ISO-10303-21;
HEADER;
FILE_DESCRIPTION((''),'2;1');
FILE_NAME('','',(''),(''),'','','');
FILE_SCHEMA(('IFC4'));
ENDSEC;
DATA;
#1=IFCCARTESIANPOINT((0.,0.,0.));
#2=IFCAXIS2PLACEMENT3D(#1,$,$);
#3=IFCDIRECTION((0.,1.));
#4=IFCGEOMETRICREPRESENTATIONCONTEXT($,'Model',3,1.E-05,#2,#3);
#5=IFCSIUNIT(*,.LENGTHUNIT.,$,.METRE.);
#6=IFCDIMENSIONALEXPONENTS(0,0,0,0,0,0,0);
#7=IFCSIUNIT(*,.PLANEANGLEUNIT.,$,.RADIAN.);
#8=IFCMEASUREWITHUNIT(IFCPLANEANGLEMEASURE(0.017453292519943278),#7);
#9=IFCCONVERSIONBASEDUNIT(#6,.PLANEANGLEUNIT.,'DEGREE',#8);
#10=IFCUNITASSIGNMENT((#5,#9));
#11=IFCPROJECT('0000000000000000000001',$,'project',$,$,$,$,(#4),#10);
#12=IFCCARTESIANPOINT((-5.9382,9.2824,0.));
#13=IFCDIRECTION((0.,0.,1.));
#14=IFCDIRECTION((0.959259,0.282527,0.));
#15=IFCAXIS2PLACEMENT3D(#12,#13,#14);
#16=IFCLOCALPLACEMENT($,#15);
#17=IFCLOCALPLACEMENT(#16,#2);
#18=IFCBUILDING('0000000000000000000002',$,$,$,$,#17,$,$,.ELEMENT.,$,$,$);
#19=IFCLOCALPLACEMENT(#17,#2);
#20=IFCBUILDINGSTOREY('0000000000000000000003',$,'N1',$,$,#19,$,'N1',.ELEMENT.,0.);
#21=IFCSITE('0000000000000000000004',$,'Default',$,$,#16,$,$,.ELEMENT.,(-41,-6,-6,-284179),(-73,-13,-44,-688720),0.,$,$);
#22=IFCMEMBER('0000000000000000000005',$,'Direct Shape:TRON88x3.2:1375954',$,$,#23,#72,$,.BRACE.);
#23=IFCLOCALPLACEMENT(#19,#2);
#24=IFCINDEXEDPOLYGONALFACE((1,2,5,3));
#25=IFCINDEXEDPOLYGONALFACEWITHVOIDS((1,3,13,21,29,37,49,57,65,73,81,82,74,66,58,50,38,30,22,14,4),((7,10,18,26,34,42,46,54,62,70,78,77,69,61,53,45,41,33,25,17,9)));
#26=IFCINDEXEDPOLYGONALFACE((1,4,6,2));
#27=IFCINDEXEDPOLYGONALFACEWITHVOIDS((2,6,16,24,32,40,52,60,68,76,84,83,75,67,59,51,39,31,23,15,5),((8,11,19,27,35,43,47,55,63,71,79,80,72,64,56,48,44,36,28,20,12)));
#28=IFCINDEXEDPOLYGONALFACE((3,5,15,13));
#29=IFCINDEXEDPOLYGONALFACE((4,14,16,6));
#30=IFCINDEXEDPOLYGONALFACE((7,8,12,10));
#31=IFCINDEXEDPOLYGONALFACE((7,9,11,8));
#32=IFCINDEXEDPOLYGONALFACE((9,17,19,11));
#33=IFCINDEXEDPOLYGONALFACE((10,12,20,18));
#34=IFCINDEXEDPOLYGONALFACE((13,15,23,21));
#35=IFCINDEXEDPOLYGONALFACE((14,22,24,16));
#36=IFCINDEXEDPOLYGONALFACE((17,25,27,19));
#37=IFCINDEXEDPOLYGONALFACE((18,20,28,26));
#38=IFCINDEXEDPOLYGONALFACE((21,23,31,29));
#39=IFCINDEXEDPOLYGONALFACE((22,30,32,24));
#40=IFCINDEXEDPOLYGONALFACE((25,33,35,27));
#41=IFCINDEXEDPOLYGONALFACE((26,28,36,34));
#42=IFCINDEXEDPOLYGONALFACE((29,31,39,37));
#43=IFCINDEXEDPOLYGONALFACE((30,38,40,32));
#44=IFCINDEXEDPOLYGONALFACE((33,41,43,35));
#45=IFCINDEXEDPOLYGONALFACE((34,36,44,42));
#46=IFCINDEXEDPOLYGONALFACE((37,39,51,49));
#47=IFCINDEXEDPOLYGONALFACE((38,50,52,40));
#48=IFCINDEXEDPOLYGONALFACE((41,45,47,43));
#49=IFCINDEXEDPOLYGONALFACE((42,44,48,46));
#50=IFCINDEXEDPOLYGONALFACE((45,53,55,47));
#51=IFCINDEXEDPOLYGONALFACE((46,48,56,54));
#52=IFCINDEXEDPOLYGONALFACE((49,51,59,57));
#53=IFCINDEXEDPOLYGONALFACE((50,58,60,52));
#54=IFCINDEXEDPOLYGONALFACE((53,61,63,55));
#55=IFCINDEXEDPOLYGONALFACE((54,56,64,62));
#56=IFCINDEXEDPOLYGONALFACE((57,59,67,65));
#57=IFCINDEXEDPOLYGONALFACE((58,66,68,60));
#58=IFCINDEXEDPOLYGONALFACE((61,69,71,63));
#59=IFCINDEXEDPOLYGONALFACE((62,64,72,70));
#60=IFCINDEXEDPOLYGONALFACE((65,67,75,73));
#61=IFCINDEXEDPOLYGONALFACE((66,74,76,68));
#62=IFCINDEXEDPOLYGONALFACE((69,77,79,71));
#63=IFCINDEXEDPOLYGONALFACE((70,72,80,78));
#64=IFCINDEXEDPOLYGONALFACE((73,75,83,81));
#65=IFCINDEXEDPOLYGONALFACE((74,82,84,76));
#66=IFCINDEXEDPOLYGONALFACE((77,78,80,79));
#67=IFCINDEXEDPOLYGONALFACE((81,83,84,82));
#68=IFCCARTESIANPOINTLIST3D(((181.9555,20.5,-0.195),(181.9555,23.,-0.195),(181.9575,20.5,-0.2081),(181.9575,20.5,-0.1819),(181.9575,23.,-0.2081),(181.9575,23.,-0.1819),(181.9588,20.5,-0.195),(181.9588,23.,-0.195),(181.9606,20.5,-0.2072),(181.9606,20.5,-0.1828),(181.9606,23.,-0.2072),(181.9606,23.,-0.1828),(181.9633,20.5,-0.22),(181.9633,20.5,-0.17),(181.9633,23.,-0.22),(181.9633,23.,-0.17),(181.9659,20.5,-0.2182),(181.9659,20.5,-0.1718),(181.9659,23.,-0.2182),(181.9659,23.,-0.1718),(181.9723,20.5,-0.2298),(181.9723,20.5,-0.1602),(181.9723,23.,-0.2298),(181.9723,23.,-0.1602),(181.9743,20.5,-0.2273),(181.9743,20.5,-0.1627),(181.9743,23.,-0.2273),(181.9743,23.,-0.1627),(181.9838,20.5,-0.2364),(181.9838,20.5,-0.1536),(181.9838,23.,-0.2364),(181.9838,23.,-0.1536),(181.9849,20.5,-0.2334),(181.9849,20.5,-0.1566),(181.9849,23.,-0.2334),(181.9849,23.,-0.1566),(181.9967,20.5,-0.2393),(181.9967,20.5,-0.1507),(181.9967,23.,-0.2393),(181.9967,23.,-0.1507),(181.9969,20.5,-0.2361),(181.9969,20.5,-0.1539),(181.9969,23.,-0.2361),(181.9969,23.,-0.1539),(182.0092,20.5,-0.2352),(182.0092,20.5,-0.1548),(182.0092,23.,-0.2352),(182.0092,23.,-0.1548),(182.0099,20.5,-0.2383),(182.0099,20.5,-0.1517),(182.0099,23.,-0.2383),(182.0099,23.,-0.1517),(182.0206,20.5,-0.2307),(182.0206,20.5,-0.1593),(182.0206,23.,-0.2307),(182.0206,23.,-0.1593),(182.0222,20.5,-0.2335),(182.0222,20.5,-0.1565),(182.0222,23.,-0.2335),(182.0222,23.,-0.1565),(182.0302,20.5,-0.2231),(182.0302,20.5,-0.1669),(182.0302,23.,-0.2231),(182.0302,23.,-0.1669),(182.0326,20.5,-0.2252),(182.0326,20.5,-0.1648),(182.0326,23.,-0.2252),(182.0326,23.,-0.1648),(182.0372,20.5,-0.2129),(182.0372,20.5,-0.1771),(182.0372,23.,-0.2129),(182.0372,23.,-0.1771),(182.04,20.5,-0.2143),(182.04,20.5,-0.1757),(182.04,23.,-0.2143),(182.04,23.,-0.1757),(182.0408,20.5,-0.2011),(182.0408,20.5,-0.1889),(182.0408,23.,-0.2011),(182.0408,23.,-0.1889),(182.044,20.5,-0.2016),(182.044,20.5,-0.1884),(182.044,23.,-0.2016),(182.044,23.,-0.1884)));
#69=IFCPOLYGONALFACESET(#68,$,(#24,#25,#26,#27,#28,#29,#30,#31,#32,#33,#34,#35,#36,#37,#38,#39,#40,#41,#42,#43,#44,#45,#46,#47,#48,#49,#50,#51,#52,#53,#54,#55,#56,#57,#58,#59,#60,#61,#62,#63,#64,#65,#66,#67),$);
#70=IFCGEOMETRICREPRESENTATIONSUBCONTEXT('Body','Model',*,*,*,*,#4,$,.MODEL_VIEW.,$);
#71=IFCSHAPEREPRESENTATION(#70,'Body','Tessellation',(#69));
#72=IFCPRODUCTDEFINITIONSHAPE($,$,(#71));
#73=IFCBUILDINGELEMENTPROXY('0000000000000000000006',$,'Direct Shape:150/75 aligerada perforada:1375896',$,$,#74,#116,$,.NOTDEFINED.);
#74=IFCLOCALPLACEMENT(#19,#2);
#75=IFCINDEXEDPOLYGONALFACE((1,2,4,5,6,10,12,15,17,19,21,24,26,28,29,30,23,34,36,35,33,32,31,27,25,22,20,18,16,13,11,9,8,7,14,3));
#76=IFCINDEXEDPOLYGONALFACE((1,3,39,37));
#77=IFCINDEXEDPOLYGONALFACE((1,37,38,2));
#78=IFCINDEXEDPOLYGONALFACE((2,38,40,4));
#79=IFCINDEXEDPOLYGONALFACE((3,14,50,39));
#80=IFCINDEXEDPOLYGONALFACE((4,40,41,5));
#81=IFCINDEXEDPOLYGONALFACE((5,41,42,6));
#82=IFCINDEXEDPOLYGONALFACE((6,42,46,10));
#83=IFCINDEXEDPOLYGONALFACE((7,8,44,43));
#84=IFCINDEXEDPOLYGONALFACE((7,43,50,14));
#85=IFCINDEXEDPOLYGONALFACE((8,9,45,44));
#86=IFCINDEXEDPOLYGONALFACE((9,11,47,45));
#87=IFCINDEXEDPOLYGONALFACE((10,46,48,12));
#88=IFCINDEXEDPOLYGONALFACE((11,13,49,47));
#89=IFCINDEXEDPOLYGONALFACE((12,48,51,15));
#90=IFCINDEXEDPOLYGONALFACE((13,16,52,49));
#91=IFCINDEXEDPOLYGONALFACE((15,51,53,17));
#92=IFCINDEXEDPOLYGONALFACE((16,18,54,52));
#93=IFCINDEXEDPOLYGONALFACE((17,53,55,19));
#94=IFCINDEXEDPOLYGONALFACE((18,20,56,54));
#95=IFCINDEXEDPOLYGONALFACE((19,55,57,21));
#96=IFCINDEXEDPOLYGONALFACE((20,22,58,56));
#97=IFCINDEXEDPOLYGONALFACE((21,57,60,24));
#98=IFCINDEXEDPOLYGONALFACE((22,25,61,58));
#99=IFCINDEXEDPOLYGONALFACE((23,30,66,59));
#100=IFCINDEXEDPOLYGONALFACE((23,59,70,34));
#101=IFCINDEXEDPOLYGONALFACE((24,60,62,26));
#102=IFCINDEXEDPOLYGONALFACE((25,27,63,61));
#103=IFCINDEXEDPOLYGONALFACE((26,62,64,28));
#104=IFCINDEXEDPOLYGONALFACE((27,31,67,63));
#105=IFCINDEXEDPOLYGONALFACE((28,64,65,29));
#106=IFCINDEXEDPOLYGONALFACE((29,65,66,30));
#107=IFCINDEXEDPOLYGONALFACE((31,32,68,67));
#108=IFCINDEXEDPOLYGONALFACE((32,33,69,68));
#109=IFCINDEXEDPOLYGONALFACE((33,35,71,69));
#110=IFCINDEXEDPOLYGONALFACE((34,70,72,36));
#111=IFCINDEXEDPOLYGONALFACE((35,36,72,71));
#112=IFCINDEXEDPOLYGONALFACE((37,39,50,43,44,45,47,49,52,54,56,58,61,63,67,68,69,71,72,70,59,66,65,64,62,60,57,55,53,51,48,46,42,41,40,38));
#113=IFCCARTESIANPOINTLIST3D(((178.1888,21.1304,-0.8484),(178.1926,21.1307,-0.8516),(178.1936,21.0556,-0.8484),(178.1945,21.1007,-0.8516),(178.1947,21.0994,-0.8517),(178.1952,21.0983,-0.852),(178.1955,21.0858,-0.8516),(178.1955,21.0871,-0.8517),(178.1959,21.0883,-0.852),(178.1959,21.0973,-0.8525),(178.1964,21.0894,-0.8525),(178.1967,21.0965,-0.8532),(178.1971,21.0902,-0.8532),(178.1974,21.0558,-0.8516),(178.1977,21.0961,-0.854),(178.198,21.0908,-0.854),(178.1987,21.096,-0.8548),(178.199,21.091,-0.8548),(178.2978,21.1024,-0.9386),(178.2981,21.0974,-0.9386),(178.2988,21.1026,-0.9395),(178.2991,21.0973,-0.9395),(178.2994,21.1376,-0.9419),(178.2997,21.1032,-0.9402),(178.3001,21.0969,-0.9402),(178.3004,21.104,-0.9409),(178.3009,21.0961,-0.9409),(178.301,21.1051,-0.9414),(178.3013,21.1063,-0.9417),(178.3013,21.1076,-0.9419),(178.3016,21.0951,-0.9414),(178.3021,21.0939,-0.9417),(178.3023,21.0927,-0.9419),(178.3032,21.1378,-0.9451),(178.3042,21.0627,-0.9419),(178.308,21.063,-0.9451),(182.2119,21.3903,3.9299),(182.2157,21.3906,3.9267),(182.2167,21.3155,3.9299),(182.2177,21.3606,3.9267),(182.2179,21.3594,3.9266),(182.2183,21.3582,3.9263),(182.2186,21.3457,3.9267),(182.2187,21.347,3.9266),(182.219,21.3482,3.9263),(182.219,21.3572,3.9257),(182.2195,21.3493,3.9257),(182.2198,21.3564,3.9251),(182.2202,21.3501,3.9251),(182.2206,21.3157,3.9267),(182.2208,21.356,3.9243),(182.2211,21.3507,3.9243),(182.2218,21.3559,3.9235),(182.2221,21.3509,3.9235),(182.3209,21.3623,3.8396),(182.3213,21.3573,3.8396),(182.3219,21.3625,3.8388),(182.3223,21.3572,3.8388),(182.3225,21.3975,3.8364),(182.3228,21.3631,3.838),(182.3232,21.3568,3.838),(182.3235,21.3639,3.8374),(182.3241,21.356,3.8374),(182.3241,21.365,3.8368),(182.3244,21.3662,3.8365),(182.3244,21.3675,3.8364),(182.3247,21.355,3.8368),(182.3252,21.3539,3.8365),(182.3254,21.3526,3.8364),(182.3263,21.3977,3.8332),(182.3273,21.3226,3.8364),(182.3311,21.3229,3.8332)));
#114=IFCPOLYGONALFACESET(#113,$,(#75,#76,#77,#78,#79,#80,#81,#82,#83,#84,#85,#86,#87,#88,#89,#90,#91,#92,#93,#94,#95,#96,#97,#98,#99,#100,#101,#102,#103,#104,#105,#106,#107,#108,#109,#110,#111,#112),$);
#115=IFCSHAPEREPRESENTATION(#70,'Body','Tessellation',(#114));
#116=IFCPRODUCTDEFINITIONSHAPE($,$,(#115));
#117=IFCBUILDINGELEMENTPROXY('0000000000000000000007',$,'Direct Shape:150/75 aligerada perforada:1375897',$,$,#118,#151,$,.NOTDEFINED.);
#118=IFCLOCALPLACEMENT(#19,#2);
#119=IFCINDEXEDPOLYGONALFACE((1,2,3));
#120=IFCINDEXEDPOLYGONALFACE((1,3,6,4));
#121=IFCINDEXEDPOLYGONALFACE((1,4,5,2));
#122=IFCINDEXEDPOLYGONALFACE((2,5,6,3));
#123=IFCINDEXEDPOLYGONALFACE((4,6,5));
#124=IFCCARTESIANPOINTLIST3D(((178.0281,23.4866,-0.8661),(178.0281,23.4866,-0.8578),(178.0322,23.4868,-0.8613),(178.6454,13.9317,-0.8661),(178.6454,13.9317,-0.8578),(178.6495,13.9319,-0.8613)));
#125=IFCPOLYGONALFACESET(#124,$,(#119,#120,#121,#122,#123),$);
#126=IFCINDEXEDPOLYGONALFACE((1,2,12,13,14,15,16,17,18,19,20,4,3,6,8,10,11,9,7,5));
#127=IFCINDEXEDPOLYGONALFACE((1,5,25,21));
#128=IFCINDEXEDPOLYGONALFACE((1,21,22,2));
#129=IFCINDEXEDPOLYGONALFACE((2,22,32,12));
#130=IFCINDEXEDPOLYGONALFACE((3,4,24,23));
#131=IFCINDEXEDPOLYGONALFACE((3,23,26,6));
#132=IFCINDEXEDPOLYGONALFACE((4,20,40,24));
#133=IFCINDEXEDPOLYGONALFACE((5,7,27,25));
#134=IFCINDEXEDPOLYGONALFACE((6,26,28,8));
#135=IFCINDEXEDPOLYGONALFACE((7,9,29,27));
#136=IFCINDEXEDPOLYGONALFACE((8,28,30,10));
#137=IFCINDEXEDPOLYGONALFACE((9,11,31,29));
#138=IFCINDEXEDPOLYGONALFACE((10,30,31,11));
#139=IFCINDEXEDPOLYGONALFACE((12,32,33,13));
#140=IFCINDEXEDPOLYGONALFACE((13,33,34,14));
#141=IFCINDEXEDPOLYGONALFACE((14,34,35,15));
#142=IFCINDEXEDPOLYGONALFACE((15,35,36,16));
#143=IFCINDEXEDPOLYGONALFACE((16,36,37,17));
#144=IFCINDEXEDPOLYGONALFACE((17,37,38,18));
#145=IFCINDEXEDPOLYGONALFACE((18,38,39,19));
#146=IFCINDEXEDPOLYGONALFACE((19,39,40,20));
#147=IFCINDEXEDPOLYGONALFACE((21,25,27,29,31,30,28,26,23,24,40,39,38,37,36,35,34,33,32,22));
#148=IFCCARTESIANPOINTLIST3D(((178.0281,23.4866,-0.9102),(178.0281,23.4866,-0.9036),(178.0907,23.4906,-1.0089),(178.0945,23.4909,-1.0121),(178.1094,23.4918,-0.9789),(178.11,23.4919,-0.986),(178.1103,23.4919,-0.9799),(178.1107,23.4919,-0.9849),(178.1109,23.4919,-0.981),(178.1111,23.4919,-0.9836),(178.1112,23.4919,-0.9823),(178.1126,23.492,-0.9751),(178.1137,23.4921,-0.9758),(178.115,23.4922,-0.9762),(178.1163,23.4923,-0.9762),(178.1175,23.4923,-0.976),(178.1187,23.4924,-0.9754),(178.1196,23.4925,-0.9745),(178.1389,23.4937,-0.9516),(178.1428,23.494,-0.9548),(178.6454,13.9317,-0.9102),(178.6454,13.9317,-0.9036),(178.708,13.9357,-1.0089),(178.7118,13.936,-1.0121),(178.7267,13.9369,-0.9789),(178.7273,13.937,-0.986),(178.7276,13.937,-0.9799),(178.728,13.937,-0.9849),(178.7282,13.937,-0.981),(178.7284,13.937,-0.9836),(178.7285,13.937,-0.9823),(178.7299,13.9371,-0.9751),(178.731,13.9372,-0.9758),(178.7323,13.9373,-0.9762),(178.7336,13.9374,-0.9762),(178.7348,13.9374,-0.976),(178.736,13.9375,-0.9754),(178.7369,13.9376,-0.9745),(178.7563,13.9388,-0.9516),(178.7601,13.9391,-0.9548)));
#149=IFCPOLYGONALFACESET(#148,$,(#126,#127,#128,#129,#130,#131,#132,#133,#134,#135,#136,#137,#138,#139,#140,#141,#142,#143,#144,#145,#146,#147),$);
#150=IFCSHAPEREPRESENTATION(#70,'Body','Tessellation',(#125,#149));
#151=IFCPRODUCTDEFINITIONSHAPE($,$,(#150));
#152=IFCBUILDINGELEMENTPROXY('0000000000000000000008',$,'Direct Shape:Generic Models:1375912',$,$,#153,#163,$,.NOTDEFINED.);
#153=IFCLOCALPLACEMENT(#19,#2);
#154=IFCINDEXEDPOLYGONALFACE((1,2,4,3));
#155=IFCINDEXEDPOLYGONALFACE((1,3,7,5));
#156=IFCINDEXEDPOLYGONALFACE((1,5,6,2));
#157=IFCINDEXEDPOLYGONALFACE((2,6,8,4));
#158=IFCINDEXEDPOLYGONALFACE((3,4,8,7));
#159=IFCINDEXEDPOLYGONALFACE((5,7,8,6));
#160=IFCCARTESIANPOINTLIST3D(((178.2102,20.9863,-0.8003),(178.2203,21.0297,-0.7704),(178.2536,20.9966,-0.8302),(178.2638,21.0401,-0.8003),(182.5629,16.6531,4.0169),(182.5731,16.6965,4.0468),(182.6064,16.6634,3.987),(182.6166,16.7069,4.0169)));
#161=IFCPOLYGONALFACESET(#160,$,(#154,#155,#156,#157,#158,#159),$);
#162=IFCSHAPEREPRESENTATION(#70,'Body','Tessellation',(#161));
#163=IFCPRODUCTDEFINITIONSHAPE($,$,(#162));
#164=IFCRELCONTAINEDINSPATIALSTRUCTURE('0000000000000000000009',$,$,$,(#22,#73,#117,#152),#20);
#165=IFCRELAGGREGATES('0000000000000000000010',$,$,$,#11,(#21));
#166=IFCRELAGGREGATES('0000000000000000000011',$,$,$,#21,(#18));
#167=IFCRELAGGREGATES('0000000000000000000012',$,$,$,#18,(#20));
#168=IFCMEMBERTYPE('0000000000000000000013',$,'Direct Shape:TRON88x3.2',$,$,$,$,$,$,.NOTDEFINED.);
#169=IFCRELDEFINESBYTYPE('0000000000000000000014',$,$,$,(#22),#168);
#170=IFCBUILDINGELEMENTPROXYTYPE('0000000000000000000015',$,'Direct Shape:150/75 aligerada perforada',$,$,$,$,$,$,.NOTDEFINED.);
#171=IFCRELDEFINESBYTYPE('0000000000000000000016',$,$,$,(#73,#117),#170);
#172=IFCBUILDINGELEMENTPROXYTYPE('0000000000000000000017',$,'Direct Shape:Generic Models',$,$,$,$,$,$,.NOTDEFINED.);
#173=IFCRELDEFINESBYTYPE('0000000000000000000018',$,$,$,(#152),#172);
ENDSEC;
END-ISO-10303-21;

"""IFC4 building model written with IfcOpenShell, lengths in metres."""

from ifc_helpers import new_model, entity, si_unit, converted_unit, direction, frame, frame_2d, origin, place, context, subcontext, project, spatial, polyline, circle_curve, parameter, trimmed, segment, composite_curve, rectangle, hollow_circle, outline, extrude, type_object, element, save


model = new_model("IFC4")

# Units and contexts
model_context = context("Model", 3, precision=1e-05, world=origin(), true_north=direction((0.0, 1.0)))
body_context = subcontext(model_context, "Body", "Model", "MODEL_VIEW")
ifc_project = project(units=[si_unit("LENGTHUNIT", "METRE"), converted_unit("PLANEANGLEUNIT", "DEGREE", entity("IfcPlaneAngleMeasure", 0.017453292519943278), si_unit("PLANEANGLEUNIT", "RADIAN"), dimensions=[0, 0, 0, 0, 0, 0, 0])], contexts=[model_context])

# Site, building, storey
site_placement = place(None, frame((-5.9382, 9.2824, 0.0), z_axis=(0.0, 0.0, 1.0), x_axis=(0.959259, 0.282527, 0.0)))
site = spatial("IfcSite", under=ifc_project, at=site_placement, Name="Default", CompositionType="ELEMENT", RefLatitude=(-41, -6, -6, -284179), RefLongitude=(-73, -13, -44, -688720), RefElevation=0.0)
building_placement = place(site_placement, origin())
building = spatial("IfcBuilding", under=site, at=building_placement, CompositionType="ELEMENT")
storey_placement = place(building_placement, origin())
storey = spatial("IfcBuildingStorey", under=building, at=storey_placement, Name="N1", LongName="N1", CompositionType="ELEMENT", Elevation=0.0)

# Member
member_type_1 = type_object("IfcMemberType", Name="Direct Shape:TRON88x3.2", PredefinedType="NOTDEFINED")
member_1_placement = place(storey_placement, origin())
element("IfcMember", 1, at=member_1_placement, inside=storey, type_object=member_type_1, Name="Direct Shape:TRON88x3.2:1375954", PredefinedType="BRACE", context=body_context, shape_type="SweptSolid", body=[
    extrude(hollow_circle(Radius=0.0445, WallThickness=0.0032, at=frame_2d((0.0, 0.0), x_axis=(1.0, 0.0))), frame((182.0, 20.5, -0.195), z_axis=(0.0, 1.0, 0.0), x_axis=(-1.0, 0.0, 0.0)), (0.0, 0.0, 1.0), 2.5),
])

# Building element proxies
building_element_proxy_type_1 = type_object("IfcBuildingElementProxyType", Name="Direct Shape:150/75 aligerada perforada", PredefinedType="NOTDEFINED")
proxy_1_placement = place(storey_placement, origin())
element("IfcBuildingElementProxy", 2, at=proxy_1_placement, inside=storey, type_object=building_element_proxy_type_1, Name="Direct Shape:150/75 aligerada perforada:1375896", PredefinedType="NOTDEFINED", context=body_context, shape_type="SweptSolid", body=[
    extrude(outline(composite_curve([segment(polyline([(-0.0375, -0.07), (-0.0375, -0.075)]), True, "CONTINUOUS"), segment(polyline([(-0.0375, -0.075), (0.0375, -0.075)]), True, "CONTINUOUS"), segment(polyline([(0.0375, -0.075), (0.0375, -0.07)]), True, "CONTINUOUS"), segment(polyline([(0.0375, -0.07), (0.0075, -0.07)]), True, "CONTINUOUS"), segment(trimmed(circle_curve(frame_2d((0.0075, -0.065), x_axis=(1.0, 0.0)), 0.005), [parameter(180.0)], [parameter(270.0)], True, "PARAMETER"), False, "CONTINUOUS"), segment(polyline([(0.0025, -0.065), (0.0025, 0.065)]), True, "CONTINUOUS"), segment(trimmed(circle_curve(frame_2d((0.0075, 0.065), x_axis=(1.0, 0.0)), 0.005), [parameter(90.0)], [parameter(180.0)], True, "PARAMETER"), False, "CONTINUOUS"), segment(polyline([(0.0075, 0.07), (0.0375, 0.07)]), True, "CONTINUOUS"), segment(polyline([(0.0375, 0.07), (0.0375, 0.075)]), True, "CONTINUOUS"), segment(polyline([(0.0375, 0.075), (-0.0375, 0.075)]), True, "CONTINUOUS"), segment(polyline([(-0.0375, 0.075), (-0.0375, 0.07)]), True, "CONTINUOUS"), segment(polyline([(-0.0375, 0.07), (-0.0075, 0.07)]), True, "CONTINUOUS"), segment(trimmed(circle_curve(frame_2d((-0.0075, 0.065), x_axis=(1.0, 0.0)), 0.005), [parameter(360.0)], [parameter(90.0)], True, "PARAMETER"), False, "CONTINUOUS"), segment(polyline([(-0.0025, 0.065), (-0.0025, -0.065)]), True, "CONTINUOUS"), segment(trimmed(circle_curve(frame_2d((-0.0075, -0.065), x_axis=(1.0, 0.0)), 0.005), [parameter(270.0)], [parameter(0.0)], True, "PARAMETER"), False, "CONTINUOUS"), segment(polyline([(-0.0075, -0.07), (-0.0375, -0.07)]), True, "CONTINUOUS")], self_intersect=False)), frame((178.2484, 21.0967, -0.8967), z_axis=(-0.643515, -0.041575, -0.764304), x_axis=(0.064471, -0.99792, 0.0)), (0.0, 0.0, -1.0), 6.2518),
])
proxy_2_placement = place(storey_placement, origin())
element("IfcBuildingElementProxy", 3, at=proxy_2_placement, inside=storey, type_object=building_element_proxy_type_1, Name="Direct Shape:150/75 aligerada perforada:1375897", PredefinedType="NOTDEFINED", context=body_context, shape_type="SweptSolid", body=[
    extrude(outline(polyline([(-0.0036, -0.0021), (0.0018, -0.0021), (0.0018, 0.0042), (-0.0036, -0.0021)])), frame((178.6467, 13.9318, -0.8618), z_axis=(-0.064471, 0.99792, 0.0), x_axis=(0.762769, 0.049279, -0.644791)), (0.0, 0.0, 1.0), 9.5748),
    extrude(outline(composite_curve([segment(polyline([(-0.0931, 0.0025), (-0.0889, -0.0025)]), True, "CONTINUOUS"), segment(polyline([(-0.0889, -0.0025), (0.0177, -0.0025)]), True, "CONTINUOUS"), segment(trimmed(circle_curve(frame_2d((0.0177, -0.0075), x_axis=(0.0, 1.0)), 0.005), [parameter(270.0)], [parameter(0.0)], True, "PARAMETER"), False, "CONTINUOUS"), segment(polyline([(0.0227, -0.0075), (0.0227, -0.0375)]), True, "CONTINUOUS"), segment(polyline([(0.0227, -0.0375), (0.0277, -0.0375)]), True, "CONTINUOUS"), segment(polyline([(0.0277, -0.0375), (0.0277, 0.0375)]), True, "CONTINUOUS"), segment(polyline([(0.0277, 0.0375), (0.0227, 0.0375)]), True, "CONTINUOUS"), segment(polyline([(0.0227, 0.0375), (0.0227, 0.0075)]), True, "CONTINUOUS"), segment(trimmed(circle_curve(frame_2d((0.0177, 0.0075), x_axis=(0.0, 1.0)), 0.005), [parameter(180.0)], [parameter(270.0)], True, "PARAMETER"), False, "CONTINUOUS"), segment(polyline([(0.0177, 0.0025), (-0.0931, 0.0025)]), True, "CONTINUOUS")], self_intersect=False)), frame((178.7148, 13.9361, -0.9656), z_axis=(0.064471, -0.99792, 0.0), x_axis=(0.762769, 0.049279, -0.644791)), (0.0, 0.0, -1.0), 9.5748),
])
building_element_proxy_type_2 = type_object("IfcBuildingElementProxyType", Name="Direct Shape:Generic Models", PredefinedType="NOTDEFINED")
proxy_3_placement = place(storey_placement, origin())
element("IfcBuildingElementProxy", 4, at=proxy_3_placement, inside=storey, type_object=building_element_proxy_type_2, Name="Direct Shape:Generic Models:1375912", PredefinedType="NOTDEFINED", context=body_context, shape_type="SweptSolid", body=[
    extrude(rectangle(XDim=0.0537, YDim=0.0537, at=frame_2d((0.0, 0.0), x_axis=(0.0, 1.0))), frame((178.237, 21.0132, -0.8003), z_axis=(0.557642, -0.555134, 0.61714), x_axis=(0.808136, 0.193252, -0.55639)), (0.0, 0.0, 1.0), 7.8057),
])

save(model, "model.ifc")
